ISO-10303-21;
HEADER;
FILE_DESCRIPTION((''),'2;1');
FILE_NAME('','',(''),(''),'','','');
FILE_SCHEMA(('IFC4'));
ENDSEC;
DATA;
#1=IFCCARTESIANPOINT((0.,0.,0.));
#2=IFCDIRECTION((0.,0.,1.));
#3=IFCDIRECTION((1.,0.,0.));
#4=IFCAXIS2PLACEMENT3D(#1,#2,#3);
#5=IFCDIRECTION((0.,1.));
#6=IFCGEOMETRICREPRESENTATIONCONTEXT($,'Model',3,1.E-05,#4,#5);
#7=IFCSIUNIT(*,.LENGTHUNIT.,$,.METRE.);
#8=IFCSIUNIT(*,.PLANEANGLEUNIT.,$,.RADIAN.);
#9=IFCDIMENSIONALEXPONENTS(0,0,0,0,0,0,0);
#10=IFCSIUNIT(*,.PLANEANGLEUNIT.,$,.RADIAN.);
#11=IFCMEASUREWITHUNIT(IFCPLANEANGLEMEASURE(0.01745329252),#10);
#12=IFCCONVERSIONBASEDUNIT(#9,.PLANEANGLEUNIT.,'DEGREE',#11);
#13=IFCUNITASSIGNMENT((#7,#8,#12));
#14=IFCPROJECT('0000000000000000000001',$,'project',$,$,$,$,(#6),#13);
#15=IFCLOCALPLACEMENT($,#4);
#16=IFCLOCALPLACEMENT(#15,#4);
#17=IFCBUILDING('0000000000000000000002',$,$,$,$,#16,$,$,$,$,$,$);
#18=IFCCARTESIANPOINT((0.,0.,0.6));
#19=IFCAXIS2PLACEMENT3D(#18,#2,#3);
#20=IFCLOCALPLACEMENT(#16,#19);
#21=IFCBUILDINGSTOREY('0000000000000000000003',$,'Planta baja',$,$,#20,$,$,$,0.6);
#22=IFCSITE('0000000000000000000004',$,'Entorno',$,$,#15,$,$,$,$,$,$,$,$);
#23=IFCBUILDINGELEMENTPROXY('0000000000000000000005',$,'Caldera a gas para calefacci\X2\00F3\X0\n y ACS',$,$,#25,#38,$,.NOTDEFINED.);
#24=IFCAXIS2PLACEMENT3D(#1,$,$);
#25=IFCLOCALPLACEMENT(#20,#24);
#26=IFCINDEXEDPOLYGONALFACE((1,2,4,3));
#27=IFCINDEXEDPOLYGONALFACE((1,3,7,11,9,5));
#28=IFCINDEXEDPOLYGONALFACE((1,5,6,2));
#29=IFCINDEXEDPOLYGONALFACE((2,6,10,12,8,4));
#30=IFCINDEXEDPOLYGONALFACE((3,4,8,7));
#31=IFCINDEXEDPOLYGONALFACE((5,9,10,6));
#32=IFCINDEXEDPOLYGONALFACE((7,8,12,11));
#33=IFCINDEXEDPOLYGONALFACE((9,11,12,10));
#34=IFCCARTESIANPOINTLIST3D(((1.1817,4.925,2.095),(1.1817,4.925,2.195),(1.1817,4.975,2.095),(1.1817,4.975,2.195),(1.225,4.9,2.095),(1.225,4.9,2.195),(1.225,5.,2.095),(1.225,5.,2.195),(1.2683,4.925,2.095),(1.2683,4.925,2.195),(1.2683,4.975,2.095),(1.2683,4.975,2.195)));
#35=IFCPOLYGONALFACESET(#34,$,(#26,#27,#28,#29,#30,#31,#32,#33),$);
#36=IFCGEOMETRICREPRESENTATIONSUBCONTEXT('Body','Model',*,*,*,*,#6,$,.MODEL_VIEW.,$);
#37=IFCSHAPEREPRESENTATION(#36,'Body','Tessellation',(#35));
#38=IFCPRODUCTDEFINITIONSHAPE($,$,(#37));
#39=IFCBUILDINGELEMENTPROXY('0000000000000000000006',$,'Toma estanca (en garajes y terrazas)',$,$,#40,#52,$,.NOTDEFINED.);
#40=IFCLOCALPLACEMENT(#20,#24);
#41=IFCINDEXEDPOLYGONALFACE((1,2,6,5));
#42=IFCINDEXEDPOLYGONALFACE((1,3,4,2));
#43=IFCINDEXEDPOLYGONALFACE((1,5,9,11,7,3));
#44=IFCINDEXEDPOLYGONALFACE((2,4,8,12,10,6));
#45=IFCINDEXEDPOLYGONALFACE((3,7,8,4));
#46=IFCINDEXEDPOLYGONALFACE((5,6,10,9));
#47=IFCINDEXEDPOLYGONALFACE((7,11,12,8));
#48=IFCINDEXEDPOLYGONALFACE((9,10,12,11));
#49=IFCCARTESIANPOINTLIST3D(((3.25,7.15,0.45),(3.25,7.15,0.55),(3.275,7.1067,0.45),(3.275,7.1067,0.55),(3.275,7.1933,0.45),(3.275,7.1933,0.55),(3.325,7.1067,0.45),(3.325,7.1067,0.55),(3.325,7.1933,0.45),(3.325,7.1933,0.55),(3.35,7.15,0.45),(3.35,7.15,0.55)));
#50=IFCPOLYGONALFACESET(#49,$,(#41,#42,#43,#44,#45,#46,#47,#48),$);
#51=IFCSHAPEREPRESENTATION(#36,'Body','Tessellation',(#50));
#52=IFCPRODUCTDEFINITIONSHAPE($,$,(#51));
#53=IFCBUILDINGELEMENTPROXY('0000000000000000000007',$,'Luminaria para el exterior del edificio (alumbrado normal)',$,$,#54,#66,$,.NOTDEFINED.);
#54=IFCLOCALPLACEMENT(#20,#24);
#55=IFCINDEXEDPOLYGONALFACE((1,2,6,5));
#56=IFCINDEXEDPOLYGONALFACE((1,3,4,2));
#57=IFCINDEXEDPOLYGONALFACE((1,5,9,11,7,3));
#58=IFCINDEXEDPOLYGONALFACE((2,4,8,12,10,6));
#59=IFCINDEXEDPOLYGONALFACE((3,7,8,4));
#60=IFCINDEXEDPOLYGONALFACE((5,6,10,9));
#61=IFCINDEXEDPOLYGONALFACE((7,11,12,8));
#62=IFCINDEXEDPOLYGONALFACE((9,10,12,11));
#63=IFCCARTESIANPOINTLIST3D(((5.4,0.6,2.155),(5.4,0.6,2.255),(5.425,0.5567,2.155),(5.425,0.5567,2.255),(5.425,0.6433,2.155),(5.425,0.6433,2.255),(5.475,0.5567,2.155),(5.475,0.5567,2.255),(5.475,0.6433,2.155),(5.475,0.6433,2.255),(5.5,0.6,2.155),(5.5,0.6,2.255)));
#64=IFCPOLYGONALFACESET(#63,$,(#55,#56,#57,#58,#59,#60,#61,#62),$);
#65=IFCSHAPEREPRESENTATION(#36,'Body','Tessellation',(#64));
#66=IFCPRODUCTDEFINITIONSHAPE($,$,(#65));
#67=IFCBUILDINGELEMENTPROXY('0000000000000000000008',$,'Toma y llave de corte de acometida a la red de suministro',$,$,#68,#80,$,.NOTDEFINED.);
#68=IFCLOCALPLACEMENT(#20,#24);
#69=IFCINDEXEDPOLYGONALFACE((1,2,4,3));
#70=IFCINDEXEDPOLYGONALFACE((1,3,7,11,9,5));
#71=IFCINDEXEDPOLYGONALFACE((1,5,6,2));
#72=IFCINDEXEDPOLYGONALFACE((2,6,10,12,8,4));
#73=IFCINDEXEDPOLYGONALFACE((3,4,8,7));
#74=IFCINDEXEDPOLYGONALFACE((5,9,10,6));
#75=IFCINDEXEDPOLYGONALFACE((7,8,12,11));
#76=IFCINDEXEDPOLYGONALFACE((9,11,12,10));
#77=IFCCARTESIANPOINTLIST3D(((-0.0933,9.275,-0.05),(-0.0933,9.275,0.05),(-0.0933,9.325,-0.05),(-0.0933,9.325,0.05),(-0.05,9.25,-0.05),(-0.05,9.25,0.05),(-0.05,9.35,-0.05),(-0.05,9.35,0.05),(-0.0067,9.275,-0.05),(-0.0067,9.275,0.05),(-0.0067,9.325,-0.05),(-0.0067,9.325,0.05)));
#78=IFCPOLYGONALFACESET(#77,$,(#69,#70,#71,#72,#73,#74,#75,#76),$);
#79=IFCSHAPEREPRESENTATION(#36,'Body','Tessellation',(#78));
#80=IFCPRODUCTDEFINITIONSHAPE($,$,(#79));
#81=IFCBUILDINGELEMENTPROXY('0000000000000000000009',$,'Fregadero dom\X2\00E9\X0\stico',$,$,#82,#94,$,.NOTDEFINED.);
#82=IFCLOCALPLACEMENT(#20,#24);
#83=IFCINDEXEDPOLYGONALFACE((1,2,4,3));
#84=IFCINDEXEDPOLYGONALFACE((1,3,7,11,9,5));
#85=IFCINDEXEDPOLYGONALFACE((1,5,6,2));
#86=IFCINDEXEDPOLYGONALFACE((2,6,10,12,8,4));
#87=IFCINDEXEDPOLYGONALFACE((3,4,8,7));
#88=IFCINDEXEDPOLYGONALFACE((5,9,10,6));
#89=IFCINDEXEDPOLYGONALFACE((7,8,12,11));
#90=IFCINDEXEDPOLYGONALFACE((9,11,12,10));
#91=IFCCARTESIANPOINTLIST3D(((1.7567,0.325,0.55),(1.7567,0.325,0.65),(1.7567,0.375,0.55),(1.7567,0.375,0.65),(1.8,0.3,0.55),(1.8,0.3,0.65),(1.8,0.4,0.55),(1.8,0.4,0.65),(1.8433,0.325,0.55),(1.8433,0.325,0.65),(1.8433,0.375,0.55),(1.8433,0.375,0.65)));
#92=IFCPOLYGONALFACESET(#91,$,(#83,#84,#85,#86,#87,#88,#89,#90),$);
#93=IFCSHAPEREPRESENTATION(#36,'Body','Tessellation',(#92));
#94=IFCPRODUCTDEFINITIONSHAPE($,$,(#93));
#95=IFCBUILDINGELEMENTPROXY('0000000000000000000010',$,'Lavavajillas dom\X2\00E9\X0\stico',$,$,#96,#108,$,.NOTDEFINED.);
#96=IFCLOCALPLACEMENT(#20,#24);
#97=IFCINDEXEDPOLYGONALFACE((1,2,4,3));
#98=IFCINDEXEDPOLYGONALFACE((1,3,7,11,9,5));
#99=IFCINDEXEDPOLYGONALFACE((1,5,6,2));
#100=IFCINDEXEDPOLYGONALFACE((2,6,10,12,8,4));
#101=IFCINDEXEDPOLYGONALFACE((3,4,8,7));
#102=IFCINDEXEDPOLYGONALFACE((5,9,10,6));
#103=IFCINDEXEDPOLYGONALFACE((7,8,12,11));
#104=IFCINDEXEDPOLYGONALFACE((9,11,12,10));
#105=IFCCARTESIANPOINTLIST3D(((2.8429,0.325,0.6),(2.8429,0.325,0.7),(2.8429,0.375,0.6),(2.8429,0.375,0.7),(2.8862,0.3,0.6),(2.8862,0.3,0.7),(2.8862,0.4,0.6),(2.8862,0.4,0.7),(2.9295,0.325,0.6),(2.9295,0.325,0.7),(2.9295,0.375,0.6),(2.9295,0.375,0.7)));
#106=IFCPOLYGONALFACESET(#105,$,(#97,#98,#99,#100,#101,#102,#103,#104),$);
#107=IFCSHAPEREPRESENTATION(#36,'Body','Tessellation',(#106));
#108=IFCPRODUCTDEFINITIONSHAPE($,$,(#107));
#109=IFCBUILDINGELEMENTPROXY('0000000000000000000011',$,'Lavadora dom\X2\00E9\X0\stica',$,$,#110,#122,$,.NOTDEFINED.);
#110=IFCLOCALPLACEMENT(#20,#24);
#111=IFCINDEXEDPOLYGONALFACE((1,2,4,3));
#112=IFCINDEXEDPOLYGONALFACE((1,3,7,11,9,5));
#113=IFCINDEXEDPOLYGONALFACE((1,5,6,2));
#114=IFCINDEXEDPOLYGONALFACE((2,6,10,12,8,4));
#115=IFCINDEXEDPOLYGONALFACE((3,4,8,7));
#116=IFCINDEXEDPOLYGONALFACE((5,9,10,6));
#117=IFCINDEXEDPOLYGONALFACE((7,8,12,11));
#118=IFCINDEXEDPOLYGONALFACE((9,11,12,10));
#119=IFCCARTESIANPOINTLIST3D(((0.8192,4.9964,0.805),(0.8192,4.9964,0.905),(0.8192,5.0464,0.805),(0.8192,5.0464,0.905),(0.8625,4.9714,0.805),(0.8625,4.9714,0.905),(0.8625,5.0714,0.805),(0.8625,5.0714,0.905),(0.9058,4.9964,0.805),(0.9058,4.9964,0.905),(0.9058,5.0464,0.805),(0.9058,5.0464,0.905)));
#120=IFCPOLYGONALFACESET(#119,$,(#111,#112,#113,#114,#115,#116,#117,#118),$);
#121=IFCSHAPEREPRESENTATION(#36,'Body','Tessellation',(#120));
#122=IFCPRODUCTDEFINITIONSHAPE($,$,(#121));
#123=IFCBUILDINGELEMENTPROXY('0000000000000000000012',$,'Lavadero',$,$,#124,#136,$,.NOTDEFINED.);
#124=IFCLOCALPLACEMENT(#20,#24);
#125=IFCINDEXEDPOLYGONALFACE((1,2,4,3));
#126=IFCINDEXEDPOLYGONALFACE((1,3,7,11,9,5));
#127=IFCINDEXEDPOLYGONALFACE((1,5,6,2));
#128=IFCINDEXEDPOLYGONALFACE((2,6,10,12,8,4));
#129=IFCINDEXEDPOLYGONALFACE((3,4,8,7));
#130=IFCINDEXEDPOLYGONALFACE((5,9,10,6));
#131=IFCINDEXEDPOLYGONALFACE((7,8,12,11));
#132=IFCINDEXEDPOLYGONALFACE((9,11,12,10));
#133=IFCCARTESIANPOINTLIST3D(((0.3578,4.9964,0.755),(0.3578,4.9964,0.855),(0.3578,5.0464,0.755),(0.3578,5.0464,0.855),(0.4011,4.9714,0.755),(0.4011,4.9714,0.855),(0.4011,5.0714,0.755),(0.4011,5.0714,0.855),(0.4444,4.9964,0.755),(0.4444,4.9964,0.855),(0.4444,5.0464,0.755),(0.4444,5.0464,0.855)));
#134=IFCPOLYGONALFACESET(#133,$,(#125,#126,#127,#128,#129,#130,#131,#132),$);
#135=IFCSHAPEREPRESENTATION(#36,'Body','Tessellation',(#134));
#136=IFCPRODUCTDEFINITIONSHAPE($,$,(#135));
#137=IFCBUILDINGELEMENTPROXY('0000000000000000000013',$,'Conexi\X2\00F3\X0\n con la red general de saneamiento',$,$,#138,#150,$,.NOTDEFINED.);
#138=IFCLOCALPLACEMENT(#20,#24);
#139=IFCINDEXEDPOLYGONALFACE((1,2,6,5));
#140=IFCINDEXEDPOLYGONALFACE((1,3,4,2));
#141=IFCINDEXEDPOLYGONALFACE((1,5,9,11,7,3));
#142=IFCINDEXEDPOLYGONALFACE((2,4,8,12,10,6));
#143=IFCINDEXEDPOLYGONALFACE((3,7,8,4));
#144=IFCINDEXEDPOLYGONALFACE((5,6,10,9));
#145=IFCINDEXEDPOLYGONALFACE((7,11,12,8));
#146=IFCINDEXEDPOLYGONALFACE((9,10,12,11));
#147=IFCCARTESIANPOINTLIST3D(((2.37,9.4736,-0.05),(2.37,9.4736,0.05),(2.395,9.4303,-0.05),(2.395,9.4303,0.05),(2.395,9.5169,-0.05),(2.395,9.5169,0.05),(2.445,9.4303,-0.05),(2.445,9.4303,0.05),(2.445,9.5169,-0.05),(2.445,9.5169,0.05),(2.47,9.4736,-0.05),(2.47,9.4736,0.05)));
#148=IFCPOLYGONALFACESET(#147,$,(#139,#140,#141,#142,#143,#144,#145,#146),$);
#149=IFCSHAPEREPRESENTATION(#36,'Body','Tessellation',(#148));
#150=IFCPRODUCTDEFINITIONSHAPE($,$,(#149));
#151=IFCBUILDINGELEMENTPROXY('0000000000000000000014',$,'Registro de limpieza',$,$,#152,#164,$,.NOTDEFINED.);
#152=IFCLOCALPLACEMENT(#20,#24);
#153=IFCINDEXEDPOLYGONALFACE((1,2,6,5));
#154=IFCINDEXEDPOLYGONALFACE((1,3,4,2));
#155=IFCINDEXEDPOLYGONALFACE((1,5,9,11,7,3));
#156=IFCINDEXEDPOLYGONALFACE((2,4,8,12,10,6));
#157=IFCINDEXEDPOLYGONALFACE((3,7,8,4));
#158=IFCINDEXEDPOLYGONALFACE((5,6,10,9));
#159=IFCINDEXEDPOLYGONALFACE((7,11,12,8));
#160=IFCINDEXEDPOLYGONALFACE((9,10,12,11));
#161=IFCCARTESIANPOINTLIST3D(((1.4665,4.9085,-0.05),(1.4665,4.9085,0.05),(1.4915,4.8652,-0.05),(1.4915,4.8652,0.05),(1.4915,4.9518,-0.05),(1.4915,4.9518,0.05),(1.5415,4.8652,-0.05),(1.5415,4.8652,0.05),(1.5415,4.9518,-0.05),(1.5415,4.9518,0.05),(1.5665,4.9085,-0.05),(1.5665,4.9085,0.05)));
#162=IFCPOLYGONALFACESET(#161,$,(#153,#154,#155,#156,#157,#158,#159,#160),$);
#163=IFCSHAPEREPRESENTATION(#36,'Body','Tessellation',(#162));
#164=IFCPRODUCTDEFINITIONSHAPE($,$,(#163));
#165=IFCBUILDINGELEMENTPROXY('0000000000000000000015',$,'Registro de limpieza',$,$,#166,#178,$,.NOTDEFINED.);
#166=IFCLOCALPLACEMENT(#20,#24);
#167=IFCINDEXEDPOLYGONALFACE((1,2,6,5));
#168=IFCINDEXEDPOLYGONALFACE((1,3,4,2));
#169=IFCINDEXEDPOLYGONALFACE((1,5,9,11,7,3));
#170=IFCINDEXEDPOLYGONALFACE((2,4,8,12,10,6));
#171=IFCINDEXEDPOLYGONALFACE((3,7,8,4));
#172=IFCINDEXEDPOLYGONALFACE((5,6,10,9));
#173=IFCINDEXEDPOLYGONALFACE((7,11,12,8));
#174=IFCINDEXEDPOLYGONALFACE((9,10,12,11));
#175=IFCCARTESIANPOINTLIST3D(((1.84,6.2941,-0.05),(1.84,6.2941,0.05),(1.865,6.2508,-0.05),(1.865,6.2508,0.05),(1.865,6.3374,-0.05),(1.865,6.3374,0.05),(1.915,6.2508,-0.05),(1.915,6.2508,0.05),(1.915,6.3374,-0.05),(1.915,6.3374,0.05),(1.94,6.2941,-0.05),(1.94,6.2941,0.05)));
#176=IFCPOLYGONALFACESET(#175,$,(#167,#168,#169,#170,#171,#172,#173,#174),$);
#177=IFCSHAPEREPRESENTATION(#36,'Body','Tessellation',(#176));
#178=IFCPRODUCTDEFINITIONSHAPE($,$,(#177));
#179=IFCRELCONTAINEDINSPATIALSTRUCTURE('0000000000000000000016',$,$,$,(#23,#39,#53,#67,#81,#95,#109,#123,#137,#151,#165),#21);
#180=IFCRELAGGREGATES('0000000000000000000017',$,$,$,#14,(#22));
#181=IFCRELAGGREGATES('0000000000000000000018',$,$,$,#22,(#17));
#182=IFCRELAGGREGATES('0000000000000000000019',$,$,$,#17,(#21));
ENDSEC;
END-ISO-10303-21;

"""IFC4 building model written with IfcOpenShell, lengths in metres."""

from ifc_helpers import new_model, entity, si_unit, converted_unit, direction, frame, origin_with_axes, place, context, subcontext, project, spatial, polyline, outline, extrude, source, transform, mapped, element, save


model = new_model("IFC4")

# Units and contexts
model_context = context("Model", 3, precision=1e-05, world=origin_with_axes(), true_north=direction((0.0, 1.0)))
body_context = subcontext(model_context, "Body", "Model", "MODEL_VIEW")
ifc_project = project(units=[si_unit("LENGTHUNIT", "METRE"), si_unit("PLANEANGLEUNIT", "RADIAN"), converted_unit("PLANEANGLEUNIT", "DEGREE", entity("IfcPlaneAngleMeasure", 0.01745329252), si_unit("PLANEANGLEUNIT", "RADIAN"), dimensions=[0, 0, 0, 0, 0, 0, 0])], contexts=[model_context])

# Site, building, storey
site_placement = place(None, origin_with_axes())
site = spatial("IfcSite", under=ifc_project, at=site_placement, Name="Entorno")
building_placement = place(site_placement, origin_with_axes())
building = spatial("IfcBuilding", under=site, at=building_placement)
storey_placement = place(building_placement, frame((0.0, 0.0, 0.6), z_axis=(0.0, 0.0, 1.0), x_axis=(1.0, 0.0, 0.0)))
storey = spatial("IfcBuildingStorey", under=building, at=storey_placement, Name="Planta baja", Elevation=0.6)

# Building element proxies
shared_shape_1 = source(origin_with_axes(), body_context, "Body", "SolidModel", [
    extrude(outline(polyline([(0.05, 0.0), (0.025, 0.0433), (-0.025, 0.0433), (-0.05, 0.0), (-0.025, -0.0433), (0.025, -0.0433), (0.05, 0.0)])), frame((0.0, 0.0, -0.05), z_axis=(0.0, 0.0, 1.0), x_axis=(1.0, 0.0, 0.0)), (0.0, 0.0, 1.0), 0.1),
])
proxy_1_placement = place(storey_placement, frame((0.0, 0.0, -0.6), z_axis=(0.0, 0.0, 1.0), x_axis=(1.0, 0.0, 0.0)))
element("IfcBuildingElementProxy", 1, at=proxy_1_placement, inside=storey, Name="Caldera a gas para calefacción y ACS", PredefinedType="NOTDEFINED", context=body_context, shape_type="Brep", body=[
    mapped(shared_shape_1, transform((1.225, 4.95, 2.745), x_axis=(0.0, 1.0, 0.0), y_axis=(-1.0, 0.0, 0.0), z_axis=(0.0, 0.0, 1.0))),
])
shared_shape_2 = source(origin_with_axes(), body_context, "Body", "SolidModel", [
    extrude(outline(polyline([(0.05, 0.0), (0.025, 0.0433), (-0.025, 0.0433), (-0.05, 0.0), (-0.025, -0.0433), (0.025, -0.0433), (0.05, 0.0)])), frame((0.0, 0.0, -0.05), z_axis=(0.0, 0.0, 1.0), x_axis=(1.0, 0.0, 0.0)), (0.0, 0.0, 1.0), 0.1),
])
proxy_2_placement = place(storey_placement, frame((0.0, 0.0, -0.6), z_axis=(0.0, 0.0, 1.0), x_axis=(1.0, 0.0, 0.0)))
element("IfcBuildingElementProxy", 2, at=proxy_2_placement, inside=storey, Name="Toma estanca (en garajes y terrazas)", PredefinedType="NOTDEFINED", context=body_context, shape_type="Brep", body=[
    mapped(shared_shape_2, transform((3.3, 7.15, 1.1), x_axis=(-1.0, 0.0, 0.0), y_axis=(0.0, -1.0, 0.0), z_axis=(0.0, 0.0, 1.0))),
])
shared_shape_3 = source(origin_with_axes(), body_context, "Body", "SolidModel", [
    extrude(outline(polyline([(0.05, 0.0), (0.025, 0.0433), (-0.025, 0.0433), (-0.05, 0.0), (-0.025, -0.0433), (0.025, -0.0433), (0.05, 0.0)])), frame((0.0, 0.0, -0.05), z_axis=(0.0, 0.0, 1.0), x_axis=(1.0, 0.0, 0.0)), (0.0, 0.0, 1.0), 0.1),
])
proxy_3_placement = place(storey_placement, frame((0.0, 0.0, -0.6), z_axis=(0.0, 0.0, 1.0), x_axis=(1.0, 0.0, 0.0)))
element("IfcBuildingElementProxy", 3, at=proxy_3_placement, inside=storey, Name="Luminaria para el exterior del edificio (alumbrado normal)", PredefinedType="NOTDEFINED", context=body_context, shape_type="Brep", body=[
    mapped(shared_shape_3, transform((5.45, 0.6, 2.805), x_axis=(-1.0, 0.0, 0.0), y_axis=(0.0, -1.0, 0.0), z_axis=(0.0, 0.0, 1.0))),
])
shared_shape_4 = source(origin_with_axes(), body_context, "Body", "SolidModel", [
    extrude(outline(polyline([(0.05, 0.0), (0.025, 0.0433), (-0.025, 0.0433), (-0.05, 0.0), (-0.025, -0.0433), (0.025, -0.0433), (0.05, 0.0)])), frame((0.0, 0.0, -0.05), z_axis=(0.0, 0.0, 1.0), x_axis=(1.0, 0.0, 0.0)), (0.0, 0.0, 1.0), 0.1),
])
proxy_4_placement = place(storey_placement, frame((0.0, 0.0, -0.6), z_axis=(0.0, 0.0, 1.0), x_axis=(1.0, 0.0, 0.0)))
element("IfcBuildingElementProxy", 4, at=proxy_4_placement, inside=storey, Name="Toma y llave de corte de acometida a la red de suministro", PredefinedType="NOTDEFINED", context=body_context, shape_type="Brep", body=[
    mapped(shared_shape_4, transform((-0.05, 9.3, 0.6), x_axis=(0.0, -1.0, 0.0), y_axis=(1.0, 0.0, 0.0), z_axis=(0.0, 0.0, 1.0))),
])
shared_shape_5 = source(origin_with_axes(), body_context, "Body", "SolidModel", [
    extrude(outline(polyline([(0.05, 0.0), (0.025, 0.0433), (-0.025, 0.0433), (-0.05, 0.0), (-0.025, -0.0433), (0.025, -0.0433), (0.05, 0.0)])), frame((0.0, 0.0, -0.05), z_axis=(0.0, 0.0, 1.0), x_axis=(1.0, 0.0, 0.0)), (0.0, 0.0, 1.0), 0.1),
])
proxy_5_placement = place(storey_placement, frame((0.0, 0.0, -0.6), z_axis=(0.0, 0.0, 1.0), x_axis=(1.0, 0.0, 0.0)))
element("IfcBuildingElementProxy", 5, at=proxy_5_placement, inside=storey, Name="Fregadero doméstico", PredefinedType="NOTDEFINED", context=body_context, shape_type="Brep", body=[
    mapped(shared_shape_5, transform((1.8, 0.35, 1.2), x_axis=(0.0, 1.0, 0.0), y_axis=(-1.0, 0.0, 0.0), z_axis=(0.0, 0.0, 1.0))),
])
shared_shape_6 = source(origin_with_axes(), body_context, "Body", "SolidModel", [
    extrude(outline(polyline([(0.05, 0.0), (0.025, 0.0433), (-0.025, 0.0433), (-0.05, 0.0), (-0.025, -0.0433), (0.025, -0.0433), (0.05, 0.0)])), frame((0.0, 0.0, -0.05), z_axis=(0.0, 0.0, 1.0), x_axis=(1.0, 0.0, 0.0)), (0.0, 0.0, 1.0), 0.1),
])
proxy_6_placement = place(storey_placement, frame((0.0, 0.0, -0.6), z_axis=(0.0, 0.0, 1.0), x_axis=(1.0, 0.0, 0.0)))
element("IfcBuildingElementProxy", 6, at=proxy_6_placement, inside=storey, Name="Lavavajillas doméstico", PredefinedType="NOTDEFINED", context=body_context, shape_type="Brep", body=[
    mapped(shared_shape_6, transform((2.8862, 0.35, 1.25), x_axis=(0.0, 1.0, 0.0), y_axis=(-1.0, 0.0, 0.0), z_axis=(0.0, 0.0, 1.0))),
])
shared_shape_7 = source(origin_with_axes(), body_context, "Body", "SolidModel", [
    extrude(outline(polyline([(0.05, 0.0), (0.025, 0.0433), (-0.025, 0.0433), (-0.05, 0.0), (-0.025, -0.0433), (0.025, -0.0433), (0.05, 0.0)])), frame((0.0, 0.0, -0.05), z_axis=(0.0, 0.0, 1.0), x_axis=(1.0, 0.0, 0.0)), (0.0, 0.0, 1.0), 0.1),
])
proxy_7_placement = place(storey_placement, frame((0.0, 0.0, -0.6), z_axis=(0.0, 0.0, 1.0), x_axis=(1.0, 0.0, 0.0)))
element("IfcBuildingElementProxy", 7, at=proxy_7_placement, inside=storey, Name="Lavadora doméstica", PredefinedType="NOTDEFINED", context=body_context, shape_type="Brep", body=[
    mapped(shared_shape_7, transform((0.8625, 5.0214, 1.455), x_axis=(0.0, 1.0, 0.0), y_axis=(-1.0, 0.0, 0.0), z_axis=(0.0, 0.0, 1.0))),
])
shared_shape_8 = source(origin_with_axes(), body_context, "Body", "SolidModel", [
    extrude(outline(polyline([(0.05, 0.0), (0.025, 0.0433), (-0.025, 0.0433), (-0.05, 0.0), (-0.025, -0.0433), (0.025, -0.0433), (0.05, 0.0)])), frame((0.0, 0.0, -0.05), z_axis=(0.0, 0.0, 1.0), x_axis=(1.0, 0.0, 0.0)), (0.0, 0.0, 1.0), 0.1),
])
proxy_8_placement = place(storey_placement, frame((0.0, 0.0, -0.6), z_axis=(0.0, 0.0, 1.0), x_axis=(1.0, 0.0, 0.0)))
element("IfcBuildingElementProxy", 8, at=proxy_8_placement, inside=storey, Name="Lavadero", PredefinedType="NOTDEFINED", context=body_context, shape_type="Brep", body=[
    mapped(shared_shape_8, transform((0.4011, 5.0214, 1.405), x_axis=(0.0, 1.0, 0.0), y_axis=(-1.0, 0.0, 0.0), z_axis=(0.0, 0.0, 1.0))),
])
shared_shape_9 = source(origin_with_axes(), body_context, "Body", "SolidModel", [
    extrude(outline(polyline([(0.05, 0.0), (0.025, 0.0433), (-0.025, 0.0433), (-0.05, 0.0), (-0.025, -0.0433), (0.025, -0.0433), (0.05, 0.0)])), frame((0.0, 0.0, -0.05), z_axis=(0.0, 0.0, 1.0), x_axis=(1.0, 0.0, 0.0)), (0.0, 0.0, 1.0), 0.1),
])
proxy_9_placement = place(storey_placement, frame((0.0, 0.0, -0.6), z_axis=(0.0, 0.0, 1.0), x_axis=(1.0, 0.0, 0.0)))
element("IfcBuildingElementProxy", 9, at=proxy_9_placement, inside=storey, Name="Conexión con la red general de saneamiento", PredefinedType="NOTDEFINED", context=body_context, shape_type="Brep", body=[
    mapped(shared_shape_9, transform((2.42, 9.4736, 0.6), x_axis=(1.0, 0.0, 0.0), y_axis=(0.0, 1.0, 0.0), z_axis=(0.0, 0.0, 1.0))),
])
shared_shape_10 = source(origin_with_axes(), body_context, "Body", "SolidModel", [
    extrude(outline(polyline([(0.05, 0.0), (0.025, 0.0433), (-0.025, 0.0433), (-0.05, 0.0), (-0.025, -0.0433), (0.025, -0.0433), (0.05, 0.0)])), frame((0.0, 0.0, -0.05), z_axis=(0.0, 0.0, 1.0), x_axis=(1.0, 0.0, 0.0)), (0.0, 0.0, 1.0), 0.1),
])
proxy_10_placement = place(storey_placement, frame((0.0, 0.0, -0.6), z_axis=(0.0, 0.0, 1.0), x_axis=(1.0, 0.0, 0.0)))
element("IfcBuildingElementProxy", 10, at=proxy_10_placement, inside=storey, Name="Registro de limpieza", PredefinedType="NOTDEFINED", context=body_context, shape_type="Brep", body=[
    mapped(shared_shape_10, transform((1.5165, 4.9085, 0.6), x_axis=(1.0, 0.0, 0.0), y_axis=(0.0, 1.0, 0.0), z_axis=(0.0, 0.0, 1.0))),
])
proxy_11_placement = place(storey_placement, frame((0.0, 0.0, -0.6), z_axis=(0.0, 0.0, 1.0), x_axis=(1.0, 0.0, 0.0)))
element("IfcBuildingElementProxy", 11, at=proxy_11_placement, inside=storey, Name="Registro de limpieza", PredefinedType="NOTDEFINED", context=body_context, shape_type="Brep", body=[
    mapped(shared_shape_10, transform((1.89, 6.2941, 0.6), x_axis=(1.0, 0.0, 0.0), y_axis=(0.0, 1.0, 0.0), z_axis=(0.0, 0.0, 1.0))),
])

save(model, "model.ifc")
